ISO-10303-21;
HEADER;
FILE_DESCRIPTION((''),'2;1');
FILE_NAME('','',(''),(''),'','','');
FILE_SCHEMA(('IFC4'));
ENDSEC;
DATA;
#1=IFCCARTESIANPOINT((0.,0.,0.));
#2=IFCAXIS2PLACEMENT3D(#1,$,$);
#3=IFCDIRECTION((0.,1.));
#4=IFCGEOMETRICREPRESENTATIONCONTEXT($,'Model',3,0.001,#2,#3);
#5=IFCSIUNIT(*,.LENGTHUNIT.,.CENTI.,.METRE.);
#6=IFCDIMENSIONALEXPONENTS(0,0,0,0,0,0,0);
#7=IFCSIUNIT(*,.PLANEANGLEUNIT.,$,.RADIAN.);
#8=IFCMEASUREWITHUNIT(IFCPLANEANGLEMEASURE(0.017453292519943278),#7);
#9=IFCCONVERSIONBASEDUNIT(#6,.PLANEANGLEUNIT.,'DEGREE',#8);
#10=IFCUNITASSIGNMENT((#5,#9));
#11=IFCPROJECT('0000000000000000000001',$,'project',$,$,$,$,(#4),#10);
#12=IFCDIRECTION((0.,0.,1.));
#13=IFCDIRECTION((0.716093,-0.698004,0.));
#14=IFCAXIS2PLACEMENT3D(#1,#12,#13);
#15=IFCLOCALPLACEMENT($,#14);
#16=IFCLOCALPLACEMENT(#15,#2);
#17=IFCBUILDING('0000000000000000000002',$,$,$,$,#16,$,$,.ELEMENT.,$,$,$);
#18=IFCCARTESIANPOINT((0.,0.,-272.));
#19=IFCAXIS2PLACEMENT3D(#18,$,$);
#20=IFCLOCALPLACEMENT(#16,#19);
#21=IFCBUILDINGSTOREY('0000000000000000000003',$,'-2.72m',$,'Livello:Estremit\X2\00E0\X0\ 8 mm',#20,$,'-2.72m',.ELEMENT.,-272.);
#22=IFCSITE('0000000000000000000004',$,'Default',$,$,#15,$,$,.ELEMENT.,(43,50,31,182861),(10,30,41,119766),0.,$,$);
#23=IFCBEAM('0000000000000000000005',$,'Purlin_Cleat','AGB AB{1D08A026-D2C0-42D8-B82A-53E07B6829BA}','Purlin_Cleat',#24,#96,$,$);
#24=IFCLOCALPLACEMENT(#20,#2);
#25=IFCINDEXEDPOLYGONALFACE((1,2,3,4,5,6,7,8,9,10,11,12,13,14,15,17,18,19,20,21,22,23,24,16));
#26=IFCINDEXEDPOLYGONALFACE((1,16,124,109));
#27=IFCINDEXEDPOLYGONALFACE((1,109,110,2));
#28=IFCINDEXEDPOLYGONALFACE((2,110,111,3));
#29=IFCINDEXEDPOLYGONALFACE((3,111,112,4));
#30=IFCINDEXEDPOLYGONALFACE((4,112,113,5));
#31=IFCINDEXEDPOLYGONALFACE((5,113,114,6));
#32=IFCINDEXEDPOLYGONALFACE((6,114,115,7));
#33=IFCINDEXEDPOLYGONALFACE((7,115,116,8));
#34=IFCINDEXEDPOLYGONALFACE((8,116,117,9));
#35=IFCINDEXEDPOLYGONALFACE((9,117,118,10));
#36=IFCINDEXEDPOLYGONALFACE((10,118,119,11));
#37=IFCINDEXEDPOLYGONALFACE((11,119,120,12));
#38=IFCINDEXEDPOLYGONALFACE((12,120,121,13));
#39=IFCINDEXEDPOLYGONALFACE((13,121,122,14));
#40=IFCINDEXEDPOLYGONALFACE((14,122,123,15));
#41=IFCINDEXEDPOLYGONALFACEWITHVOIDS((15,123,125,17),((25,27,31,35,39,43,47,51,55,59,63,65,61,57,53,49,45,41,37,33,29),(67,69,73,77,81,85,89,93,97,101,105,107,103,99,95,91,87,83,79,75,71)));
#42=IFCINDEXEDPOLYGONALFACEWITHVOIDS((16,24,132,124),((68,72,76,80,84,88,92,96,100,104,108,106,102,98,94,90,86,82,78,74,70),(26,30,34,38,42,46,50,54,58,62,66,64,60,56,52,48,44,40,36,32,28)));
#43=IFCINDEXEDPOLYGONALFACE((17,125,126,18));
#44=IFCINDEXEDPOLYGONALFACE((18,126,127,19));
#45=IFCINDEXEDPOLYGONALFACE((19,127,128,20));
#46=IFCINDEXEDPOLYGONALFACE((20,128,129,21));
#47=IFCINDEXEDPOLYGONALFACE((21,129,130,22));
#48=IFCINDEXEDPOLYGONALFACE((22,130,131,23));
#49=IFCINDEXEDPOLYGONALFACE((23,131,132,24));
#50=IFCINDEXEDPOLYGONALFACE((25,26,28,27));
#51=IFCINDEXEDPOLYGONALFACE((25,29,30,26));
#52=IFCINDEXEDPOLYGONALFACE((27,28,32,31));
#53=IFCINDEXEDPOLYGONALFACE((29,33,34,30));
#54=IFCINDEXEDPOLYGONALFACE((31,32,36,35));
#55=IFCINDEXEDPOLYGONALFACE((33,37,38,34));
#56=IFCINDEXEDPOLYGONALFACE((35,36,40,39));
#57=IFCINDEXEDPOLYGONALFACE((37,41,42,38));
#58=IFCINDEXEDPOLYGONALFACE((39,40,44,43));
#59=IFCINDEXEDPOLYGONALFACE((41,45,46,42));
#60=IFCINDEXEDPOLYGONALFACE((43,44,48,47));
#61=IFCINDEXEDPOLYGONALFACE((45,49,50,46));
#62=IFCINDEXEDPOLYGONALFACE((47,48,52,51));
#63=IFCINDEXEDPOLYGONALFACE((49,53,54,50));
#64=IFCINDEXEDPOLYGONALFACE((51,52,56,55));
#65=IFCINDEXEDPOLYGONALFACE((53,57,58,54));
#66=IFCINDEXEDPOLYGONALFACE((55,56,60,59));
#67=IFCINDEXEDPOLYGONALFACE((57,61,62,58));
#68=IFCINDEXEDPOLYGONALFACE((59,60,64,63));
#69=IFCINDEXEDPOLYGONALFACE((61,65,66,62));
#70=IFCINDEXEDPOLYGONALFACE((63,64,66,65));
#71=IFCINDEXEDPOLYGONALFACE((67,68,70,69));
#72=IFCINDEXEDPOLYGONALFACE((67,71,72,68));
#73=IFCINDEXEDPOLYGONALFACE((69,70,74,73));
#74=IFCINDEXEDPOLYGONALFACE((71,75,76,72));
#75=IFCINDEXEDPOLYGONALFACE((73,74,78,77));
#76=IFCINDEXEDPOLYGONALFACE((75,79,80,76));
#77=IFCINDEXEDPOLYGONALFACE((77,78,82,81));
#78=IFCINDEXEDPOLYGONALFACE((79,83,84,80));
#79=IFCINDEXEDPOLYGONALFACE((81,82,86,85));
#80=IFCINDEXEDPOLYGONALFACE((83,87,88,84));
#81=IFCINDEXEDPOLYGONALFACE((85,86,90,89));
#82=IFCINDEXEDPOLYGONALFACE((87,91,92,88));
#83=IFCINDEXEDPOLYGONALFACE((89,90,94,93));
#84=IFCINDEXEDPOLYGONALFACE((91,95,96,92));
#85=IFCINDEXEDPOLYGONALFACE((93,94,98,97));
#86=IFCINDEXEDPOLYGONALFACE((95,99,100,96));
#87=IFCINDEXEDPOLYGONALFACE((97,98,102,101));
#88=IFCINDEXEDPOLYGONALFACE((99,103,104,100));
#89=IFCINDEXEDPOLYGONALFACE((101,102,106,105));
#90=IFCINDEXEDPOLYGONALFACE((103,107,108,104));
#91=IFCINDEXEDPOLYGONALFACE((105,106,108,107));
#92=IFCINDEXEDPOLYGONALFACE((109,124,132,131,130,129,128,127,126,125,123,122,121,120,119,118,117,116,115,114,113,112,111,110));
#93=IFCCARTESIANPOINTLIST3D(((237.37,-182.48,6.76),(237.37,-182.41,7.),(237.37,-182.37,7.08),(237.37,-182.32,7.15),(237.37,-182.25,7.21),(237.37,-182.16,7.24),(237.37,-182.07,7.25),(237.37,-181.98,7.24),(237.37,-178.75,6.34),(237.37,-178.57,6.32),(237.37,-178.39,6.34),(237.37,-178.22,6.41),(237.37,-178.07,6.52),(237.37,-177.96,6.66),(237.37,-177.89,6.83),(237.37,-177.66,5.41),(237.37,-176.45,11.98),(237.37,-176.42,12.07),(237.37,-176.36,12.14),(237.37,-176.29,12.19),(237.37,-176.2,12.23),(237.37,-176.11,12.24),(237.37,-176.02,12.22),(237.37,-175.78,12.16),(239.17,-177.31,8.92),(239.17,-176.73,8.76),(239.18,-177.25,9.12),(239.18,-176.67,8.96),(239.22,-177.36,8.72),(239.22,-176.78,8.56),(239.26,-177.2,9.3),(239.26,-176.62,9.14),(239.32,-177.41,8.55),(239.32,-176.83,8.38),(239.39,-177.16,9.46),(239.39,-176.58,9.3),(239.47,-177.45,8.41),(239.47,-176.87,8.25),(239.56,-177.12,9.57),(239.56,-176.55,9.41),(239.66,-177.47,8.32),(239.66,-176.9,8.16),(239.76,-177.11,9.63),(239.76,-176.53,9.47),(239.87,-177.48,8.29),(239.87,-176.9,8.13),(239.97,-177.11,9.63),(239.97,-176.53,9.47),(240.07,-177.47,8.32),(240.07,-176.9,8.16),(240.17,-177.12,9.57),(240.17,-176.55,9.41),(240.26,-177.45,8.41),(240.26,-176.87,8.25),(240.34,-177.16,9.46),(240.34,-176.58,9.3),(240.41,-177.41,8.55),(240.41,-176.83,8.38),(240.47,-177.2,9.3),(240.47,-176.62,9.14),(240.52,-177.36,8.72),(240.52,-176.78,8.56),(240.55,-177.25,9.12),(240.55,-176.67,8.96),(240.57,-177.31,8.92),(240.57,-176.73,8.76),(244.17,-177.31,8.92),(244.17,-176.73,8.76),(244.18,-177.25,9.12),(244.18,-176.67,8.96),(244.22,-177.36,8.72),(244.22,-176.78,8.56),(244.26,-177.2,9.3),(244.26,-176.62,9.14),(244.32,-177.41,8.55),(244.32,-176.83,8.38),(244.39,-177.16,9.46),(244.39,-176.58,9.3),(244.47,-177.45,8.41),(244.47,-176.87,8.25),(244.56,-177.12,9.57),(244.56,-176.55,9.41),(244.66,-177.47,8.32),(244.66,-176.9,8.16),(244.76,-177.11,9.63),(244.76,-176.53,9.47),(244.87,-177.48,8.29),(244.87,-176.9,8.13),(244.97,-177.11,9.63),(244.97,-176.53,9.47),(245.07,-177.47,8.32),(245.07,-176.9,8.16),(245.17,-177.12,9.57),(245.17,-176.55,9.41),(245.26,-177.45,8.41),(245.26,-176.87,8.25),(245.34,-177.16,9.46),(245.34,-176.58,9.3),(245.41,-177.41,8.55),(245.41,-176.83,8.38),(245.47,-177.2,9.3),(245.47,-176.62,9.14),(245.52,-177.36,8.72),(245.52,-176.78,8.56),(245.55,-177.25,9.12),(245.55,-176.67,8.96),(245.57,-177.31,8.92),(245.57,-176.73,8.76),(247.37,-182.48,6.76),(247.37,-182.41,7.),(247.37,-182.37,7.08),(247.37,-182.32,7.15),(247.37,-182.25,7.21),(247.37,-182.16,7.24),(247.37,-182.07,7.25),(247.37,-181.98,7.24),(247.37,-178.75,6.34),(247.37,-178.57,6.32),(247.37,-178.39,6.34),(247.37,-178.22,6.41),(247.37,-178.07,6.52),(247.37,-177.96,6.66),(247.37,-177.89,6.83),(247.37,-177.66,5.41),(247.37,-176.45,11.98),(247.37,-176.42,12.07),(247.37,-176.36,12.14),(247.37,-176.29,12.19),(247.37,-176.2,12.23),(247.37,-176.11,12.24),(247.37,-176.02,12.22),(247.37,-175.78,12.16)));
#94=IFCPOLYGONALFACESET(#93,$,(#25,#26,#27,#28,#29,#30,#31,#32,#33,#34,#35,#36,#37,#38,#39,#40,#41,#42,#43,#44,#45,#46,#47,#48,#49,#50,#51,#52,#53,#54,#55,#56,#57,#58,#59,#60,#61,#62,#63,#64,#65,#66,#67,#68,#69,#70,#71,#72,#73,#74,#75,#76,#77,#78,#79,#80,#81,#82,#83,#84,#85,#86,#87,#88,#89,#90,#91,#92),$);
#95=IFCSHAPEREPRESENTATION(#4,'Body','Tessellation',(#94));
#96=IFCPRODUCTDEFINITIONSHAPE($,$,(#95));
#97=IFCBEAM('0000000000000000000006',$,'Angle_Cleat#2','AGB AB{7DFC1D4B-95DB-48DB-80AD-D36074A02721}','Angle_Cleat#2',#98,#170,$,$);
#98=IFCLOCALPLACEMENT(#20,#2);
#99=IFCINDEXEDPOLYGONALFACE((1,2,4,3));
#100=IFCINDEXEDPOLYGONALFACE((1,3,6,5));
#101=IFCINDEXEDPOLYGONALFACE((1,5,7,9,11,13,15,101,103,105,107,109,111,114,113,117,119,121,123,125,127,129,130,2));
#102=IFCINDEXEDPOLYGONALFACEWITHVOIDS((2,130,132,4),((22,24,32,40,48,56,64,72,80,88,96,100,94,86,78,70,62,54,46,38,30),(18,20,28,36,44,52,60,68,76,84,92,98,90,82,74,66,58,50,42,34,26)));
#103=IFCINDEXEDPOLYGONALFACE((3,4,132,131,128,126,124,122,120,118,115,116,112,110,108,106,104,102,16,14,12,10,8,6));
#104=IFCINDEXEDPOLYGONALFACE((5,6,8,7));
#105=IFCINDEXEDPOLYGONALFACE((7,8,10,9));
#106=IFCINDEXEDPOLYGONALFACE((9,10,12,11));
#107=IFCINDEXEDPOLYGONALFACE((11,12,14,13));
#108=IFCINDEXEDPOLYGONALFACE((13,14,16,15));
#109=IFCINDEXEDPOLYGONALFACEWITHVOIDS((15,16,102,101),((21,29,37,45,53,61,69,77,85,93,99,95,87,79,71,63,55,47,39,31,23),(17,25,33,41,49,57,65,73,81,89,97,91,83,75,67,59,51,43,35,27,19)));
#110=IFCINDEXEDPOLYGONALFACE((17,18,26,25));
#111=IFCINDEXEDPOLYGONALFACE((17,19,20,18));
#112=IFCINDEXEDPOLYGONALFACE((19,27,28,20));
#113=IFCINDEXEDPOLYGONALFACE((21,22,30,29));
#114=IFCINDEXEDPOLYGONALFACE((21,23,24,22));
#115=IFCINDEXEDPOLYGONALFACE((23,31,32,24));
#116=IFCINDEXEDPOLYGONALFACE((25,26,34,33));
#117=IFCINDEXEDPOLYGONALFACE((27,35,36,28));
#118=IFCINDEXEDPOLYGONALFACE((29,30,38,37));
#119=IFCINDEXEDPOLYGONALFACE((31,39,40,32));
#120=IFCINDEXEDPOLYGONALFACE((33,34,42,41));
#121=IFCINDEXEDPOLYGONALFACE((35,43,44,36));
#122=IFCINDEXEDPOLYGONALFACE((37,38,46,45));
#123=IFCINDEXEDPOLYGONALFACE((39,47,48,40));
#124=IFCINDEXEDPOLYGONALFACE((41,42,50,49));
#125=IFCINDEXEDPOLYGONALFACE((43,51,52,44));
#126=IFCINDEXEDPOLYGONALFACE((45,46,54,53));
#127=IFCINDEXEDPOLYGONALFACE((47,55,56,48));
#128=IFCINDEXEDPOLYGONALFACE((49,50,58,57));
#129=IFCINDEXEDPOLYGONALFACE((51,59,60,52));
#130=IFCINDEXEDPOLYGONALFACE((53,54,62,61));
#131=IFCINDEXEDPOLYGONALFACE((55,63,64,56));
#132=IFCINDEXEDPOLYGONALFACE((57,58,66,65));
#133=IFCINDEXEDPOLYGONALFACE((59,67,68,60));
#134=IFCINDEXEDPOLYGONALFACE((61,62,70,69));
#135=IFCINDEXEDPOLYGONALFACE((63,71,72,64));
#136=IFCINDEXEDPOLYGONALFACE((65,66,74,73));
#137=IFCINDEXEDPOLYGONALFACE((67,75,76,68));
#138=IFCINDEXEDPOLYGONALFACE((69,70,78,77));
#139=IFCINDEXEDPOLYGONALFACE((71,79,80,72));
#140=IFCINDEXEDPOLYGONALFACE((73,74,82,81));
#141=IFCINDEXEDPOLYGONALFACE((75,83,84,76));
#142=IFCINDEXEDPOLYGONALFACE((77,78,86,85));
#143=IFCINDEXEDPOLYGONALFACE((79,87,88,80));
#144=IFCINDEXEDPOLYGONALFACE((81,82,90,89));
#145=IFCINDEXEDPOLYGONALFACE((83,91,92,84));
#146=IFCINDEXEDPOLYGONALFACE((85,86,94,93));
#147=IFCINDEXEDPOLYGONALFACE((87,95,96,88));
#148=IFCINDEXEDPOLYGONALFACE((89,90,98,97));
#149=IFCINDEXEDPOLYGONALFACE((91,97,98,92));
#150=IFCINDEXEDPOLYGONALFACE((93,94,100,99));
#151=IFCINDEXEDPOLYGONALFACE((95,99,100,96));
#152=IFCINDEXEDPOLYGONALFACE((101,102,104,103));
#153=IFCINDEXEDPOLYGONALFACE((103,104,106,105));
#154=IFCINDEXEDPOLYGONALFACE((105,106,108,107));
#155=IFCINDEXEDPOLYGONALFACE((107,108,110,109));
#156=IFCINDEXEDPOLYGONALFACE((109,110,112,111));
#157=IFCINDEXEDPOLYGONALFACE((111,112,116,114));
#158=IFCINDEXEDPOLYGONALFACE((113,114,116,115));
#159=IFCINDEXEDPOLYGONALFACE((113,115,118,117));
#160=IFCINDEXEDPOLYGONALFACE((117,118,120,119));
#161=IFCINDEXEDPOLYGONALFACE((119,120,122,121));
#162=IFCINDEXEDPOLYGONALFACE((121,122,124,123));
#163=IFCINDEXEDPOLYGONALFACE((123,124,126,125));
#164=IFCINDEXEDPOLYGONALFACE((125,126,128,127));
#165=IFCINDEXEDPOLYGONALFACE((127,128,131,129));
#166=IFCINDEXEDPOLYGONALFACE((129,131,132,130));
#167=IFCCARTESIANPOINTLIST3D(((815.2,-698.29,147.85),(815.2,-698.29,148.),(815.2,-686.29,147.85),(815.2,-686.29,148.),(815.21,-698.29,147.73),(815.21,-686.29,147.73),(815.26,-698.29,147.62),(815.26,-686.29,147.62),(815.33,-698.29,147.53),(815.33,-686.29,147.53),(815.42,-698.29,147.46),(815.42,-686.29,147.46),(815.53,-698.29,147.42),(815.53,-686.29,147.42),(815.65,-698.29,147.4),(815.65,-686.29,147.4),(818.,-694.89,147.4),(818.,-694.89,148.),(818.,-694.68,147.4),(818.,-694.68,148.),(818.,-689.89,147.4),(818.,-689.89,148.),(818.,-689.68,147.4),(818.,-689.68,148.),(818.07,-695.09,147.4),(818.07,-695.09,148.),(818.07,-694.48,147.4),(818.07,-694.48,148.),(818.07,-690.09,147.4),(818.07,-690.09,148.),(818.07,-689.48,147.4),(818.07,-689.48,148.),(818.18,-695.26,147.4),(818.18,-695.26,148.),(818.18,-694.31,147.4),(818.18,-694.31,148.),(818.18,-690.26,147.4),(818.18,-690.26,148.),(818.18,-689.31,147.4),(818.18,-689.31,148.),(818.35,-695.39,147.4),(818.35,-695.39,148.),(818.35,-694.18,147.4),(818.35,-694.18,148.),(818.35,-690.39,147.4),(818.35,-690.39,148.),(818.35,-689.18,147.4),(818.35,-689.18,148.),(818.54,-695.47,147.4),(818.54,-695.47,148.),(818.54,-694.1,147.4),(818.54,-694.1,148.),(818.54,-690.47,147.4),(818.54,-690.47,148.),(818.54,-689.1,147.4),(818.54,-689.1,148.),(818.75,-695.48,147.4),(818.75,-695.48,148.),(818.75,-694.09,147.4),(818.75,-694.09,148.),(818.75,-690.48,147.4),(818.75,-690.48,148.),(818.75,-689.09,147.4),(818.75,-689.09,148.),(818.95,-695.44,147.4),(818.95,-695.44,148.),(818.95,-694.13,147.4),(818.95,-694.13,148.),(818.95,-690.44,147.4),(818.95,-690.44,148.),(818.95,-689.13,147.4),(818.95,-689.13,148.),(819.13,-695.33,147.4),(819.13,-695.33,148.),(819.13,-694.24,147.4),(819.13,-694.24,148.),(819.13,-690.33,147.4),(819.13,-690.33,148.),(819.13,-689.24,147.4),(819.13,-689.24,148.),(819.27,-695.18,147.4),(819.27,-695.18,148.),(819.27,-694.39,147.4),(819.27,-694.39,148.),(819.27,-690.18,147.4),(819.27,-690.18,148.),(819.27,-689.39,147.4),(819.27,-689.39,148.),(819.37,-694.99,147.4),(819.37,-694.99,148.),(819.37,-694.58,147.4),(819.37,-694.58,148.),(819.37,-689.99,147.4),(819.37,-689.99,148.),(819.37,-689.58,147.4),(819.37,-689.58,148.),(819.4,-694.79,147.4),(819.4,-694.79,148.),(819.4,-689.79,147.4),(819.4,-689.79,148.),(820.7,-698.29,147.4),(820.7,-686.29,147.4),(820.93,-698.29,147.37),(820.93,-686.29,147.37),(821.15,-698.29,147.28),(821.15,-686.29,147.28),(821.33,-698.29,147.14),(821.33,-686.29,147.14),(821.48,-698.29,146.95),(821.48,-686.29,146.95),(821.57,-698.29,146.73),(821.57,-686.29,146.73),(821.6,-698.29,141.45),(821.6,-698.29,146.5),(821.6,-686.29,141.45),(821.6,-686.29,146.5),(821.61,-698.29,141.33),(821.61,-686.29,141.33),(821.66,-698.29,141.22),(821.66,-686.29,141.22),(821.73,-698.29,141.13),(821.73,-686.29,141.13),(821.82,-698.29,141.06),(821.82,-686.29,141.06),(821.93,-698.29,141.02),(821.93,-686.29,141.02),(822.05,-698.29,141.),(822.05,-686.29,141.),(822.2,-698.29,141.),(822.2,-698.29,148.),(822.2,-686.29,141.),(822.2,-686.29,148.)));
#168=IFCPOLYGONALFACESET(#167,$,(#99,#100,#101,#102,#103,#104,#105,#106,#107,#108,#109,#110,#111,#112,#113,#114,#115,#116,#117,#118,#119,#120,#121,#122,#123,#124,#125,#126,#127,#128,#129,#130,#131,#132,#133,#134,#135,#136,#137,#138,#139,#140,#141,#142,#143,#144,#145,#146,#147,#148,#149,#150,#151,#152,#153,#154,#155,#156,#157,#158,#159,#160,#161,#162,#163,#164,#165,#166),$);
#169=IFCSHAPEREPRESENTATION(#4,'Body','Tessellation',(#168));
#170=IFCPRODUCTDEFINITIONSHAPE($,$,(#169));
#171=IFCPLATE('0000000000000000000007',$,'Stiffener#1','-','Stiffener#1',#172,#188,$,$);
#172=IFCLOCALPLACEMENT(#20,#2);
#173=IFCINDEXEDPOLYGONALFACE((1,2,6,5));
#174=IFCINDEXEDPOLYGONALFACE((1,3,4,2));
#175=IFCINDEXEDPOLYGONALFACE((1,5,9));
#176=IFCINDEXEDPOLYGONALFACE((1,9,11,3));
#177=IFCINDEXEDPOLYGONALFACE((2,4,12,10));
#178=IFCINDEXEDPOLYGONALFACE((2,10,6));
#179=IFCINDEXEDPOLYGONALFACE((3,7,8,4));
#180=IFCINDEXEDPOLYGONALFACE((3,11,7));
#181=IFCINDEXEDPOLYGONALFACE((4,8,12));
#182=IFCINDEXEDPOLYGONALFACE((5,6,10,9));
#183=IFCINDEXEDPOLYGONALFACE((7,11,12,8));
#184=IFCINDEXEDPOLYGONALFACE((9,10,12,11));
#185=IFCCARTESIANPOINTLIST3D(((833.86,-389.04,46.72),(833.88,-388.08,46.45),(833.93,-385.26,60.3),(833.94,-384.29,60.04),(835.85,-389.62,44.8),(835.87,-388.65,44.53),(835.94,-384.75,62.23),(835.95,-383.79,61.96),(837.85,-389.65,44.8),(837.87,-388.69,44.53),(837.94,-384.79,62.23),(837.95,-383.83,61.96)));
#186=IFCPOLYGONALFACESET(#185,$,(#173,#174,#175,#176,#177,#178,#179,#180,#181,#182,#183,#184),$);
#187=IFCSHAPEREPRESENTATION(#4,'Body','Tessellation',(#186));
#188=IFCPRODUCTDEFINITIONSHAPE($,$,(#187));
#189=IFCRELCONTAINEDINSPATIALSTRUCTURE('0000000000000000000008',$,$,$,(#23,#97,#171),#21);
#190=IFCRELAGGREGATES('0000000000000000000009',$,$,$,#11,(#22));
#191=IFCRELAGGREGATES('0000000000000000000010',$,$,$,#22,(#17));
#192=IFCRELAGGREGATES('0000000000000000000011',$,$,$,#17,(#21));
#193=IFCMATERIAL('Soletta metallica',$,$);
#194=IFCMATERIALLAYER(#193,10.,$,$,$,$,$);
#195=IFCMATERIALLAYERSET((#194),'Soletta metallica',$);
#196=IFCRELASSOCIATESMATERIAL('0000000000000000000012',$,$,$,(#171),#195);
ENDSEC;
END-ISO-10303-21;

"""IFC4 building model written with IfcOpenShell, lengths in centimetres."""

from ifc_helpers import new_model, entity, si_unit, converted_unit, direction, frame, frame_2d, origin, origin_with_axes, place, context, project, spatial, polyline, circle, l_section, outline, extrude, material, layer, layer_set, element, save


model = new_model("IFC4")

# Units and contexts
model_context = context("Model", 3, precision=0.001, world=origin(), true_north=direction((0.0, 1.0)))
ifc_project = project(units=[si_unit("LENGTHUNIT", "METRE", prefix="CENTI"), converted_unit("PLANEANGLEUNIT", "DEGREE", entity("IfcPlaneAngleMeasure", 0.017453292519943278), si_unit("PLANEANGLEUNIT", "RADIAN"), dimensions=[0, 0, 0, 0, 0, 0, 0])], contexts=[model_context])

# Site, building, storey
site_placement = place(None, frame((0.0, 0.0, 0.0), z_axis=(0.0, 0.0, 1.0), x_axis=(0.716093, -0.698004, 0.0)))
site = spatial("IfcSite", under=ifc_project, at=site_placement, Name="Default", CompositionType="ELEMENT", RefLatitude=(43, 50, 31, 182861), RefLongitude=(10, 30, 41, 119766), RefElevation=0.0)
building_placement = place(site_placement, origin())
building = spatial("IfcBuilding", under=site, at=building_placement, CompositionType="ELEMENT")
storey_placement = place(building_placement, frame((0.0, 0.0, -272.0)))
storey = spatial("IfcBuildingStorey", under=building, at=storey_placement, Name="-2.72m", ObjectType="Livello:Estremità 8 mm", LongName="-2.72m", CompositionType="ELEMENT", Elevation=-272.0)

# Beams, openings
beam_1_placement = place(storey_placement, frame((247.37, -178.24, 7.91), z_axis=(1.0, 0.0, 0.0), x_axis=(0.0, 0.268584, 0.963256)))
beam_1 = element("IfcBeam", 1, at=beam_1_placement, inside=storey, Name="Purlin_Cleat", Description="AGB AB{1D08A026-D2C0-42D8-B82A-53E07B6829BA}", ObjectType="Purlin_Cleat", context=model_context, shape_type="SweptSolid", body=[
    extrude(l_section(Depth=5.0, Width=7.0, Thickness=0.6, FilletRadius=0.7, EdgeRadius=0.35, at=frame_2d((1.25, 1.27))), origin(), (0.0, 0.0, -1.0), 10.0),
])
opening_1_placement = place(beam_1_placement, frame((1.27, -0.6, -3.2), z_axis=(0.0, 1.0, 0.0), x_axis=(-1.0, 0.0, 0.0)))
element("IfcOpeningElement", 2, at=opening_1_placement, cuts=beam_1, ObjectType="Opening", context=model_context, shape_type="SweptSolid", body=[
    extrude(circle(Radius=0.7, at=frame_2d((0.0, 0.7), x_axis=(1.0, 0.0))), origin(), (0.0, 0.0, -1.0), 0.7),
])
opening_2_placement = place(beam_1_placement, frame((1.27, -0.6, -8.2), z_axis=(0.0, 1.0, 0.0), x_axis=(-1.0, 0.0, 0.0)))
element("IfcOpeningElement", 3, at=opening_2_placement, cuts=beam_1, ObjectType="Opening", context=model_context, shape_type="SweptSolid", body=[
    extrude(circle(Radius=0.7, at=frame_2d((0.0, 0.7), x_axis=(1.0, 0.0))), origin(), (0.0, 0.0, -1.0), 0.7),
])
beam_2_placement = place(storey_placement, frame((820.27, -698.29, 146.07), z_axis=(0.0, -1.0, 0.0), x_axis=(-1.0, 0.0, 0.0)))
beam_2 = element("IfcBeam", 4, at=beam_2_placement, inside=storey, Name="Angle_Cleat#2", Description="AGB AB{7DFC1D4B-95DB-48DB-80AD-D36074A02721}", ObjectType="Angle_Cleat#2", context=model_context, shape_type="SweptSolid", body=[
    extrude(l_section(Depth=7.0, Width=7.0, Thickness=0.6, FilletRadius=0.9, EdgeRadius=0.45, at=frame_2d((1.57, 1.57))), origin(), (0.0, 0.0, -1.0), 12.0),
])
opening_3_placement = place(beam_2_placement, frame((1.57, -1.28, -4.2), z_axis=(0.0, 1.0, 0.0), x_axis=(-1.0, 0.0, 0.0)))
element("IfcOpeningElement", 5, at=opening_3_placement, cuts=beam_2, ObjectType="Opening", context=model_context, shape_type="SweptSolid", body=[
    extrude(circle(Radius=0.7, at=frame_2d((0.0, 0.7), x_axis=(1.0, 0.0))), origin(), (0.0, 0.0, -1.0), 0.7),
])
opening_4_placement = place(beam_2_placement, frame((1.57, -1.28, -9.2), z_axis=(0.0, 1.0, 0.0), x_axis=(-1.0, 0.0, 0.0)))
element("IfcOpeningElement", 6, at=opening_4_placement, cuts=beam_2, ObjectType="Opening", context=model_context, shape_type="SweptSolid", body=[
    extrude(circle(Radius=0.7, at=frame_2d((0.0, 0.7), x_axis=(1.0, 0.0))), origin(), (0.0, 0.0, -1.0), 0.7),
])

# Shared definitions
ifc_material = material(Name="Soletta metallica")

# Plate, openings
ifc_layer_1 = layer(ifc_material, 10.0)
ifc_layer_set_1 = layer_set([ifc_layer_1], Name="Soletta metallica")
plate_1_placement = place(storey_placement, frame((837.95, -383.83, 61.96), z_axis=(-0.0171, -0.963097, 0.268612), x_axis=(-0.999842, 0.017752, 0.0)))
plate_1 = element("IfcPlate", 7, at=plate_1_placement, inside=storey, material=ifc_layer_set_1, Name="Stiffener#1", Description="-", ObjectType="Stiffener#1", context=model_context, shape_type="SweptSolid", body=[
    extrude(outline(polyline([(0.0, 0.0), (4.0, 0.0), (4.0, 18.1), (0.0, 18.1), (0.0, 0.0)])), origin_with_axes(), (0.0, 0.0, 1.0), 1.0),
])
opening_5_placement = place(plate_1_placement, frame((0.0, 0.0, 0.0), z_axis=(0.0, 0.0, 1.0), x_axis=(1.0, 0.0, 0.0)))
element("IfcOpeningElement", 8, at=opening_5_placement, cuts=plate_1, ObjectType="Opening", context=model_context, shape_type="SweptSolid", body=[
    extrude(outline(polyline([(4.0, 18.1), (2.0, 18.1), (4.0, 16.1), (4.0, 18.1)])), origin(), (0.0, 0.0, 1.0), 1.0),
])
opening_6_placement = place(plate_1_placement, frame((0.0, 0.0, 0.0), z_axis=(0.0, 0.0, 1.0), x_axis=(1.0, 0.0, 0.0)))
element("IfcOpeningElement", 9, at=opening_6_placement, cuts=plate_1, ObjectType="Opening", context=model_context, shape_type="SweptSolid", body=[
    extrude(outline(polyline([(4.0, 0.0), (4.0, 2.0), (2.0, 0.0), (4.0, 0.0)])), origin(), (0.0, 0.0, 1.0), 1.0),
])

save(model, "model.ifc")
